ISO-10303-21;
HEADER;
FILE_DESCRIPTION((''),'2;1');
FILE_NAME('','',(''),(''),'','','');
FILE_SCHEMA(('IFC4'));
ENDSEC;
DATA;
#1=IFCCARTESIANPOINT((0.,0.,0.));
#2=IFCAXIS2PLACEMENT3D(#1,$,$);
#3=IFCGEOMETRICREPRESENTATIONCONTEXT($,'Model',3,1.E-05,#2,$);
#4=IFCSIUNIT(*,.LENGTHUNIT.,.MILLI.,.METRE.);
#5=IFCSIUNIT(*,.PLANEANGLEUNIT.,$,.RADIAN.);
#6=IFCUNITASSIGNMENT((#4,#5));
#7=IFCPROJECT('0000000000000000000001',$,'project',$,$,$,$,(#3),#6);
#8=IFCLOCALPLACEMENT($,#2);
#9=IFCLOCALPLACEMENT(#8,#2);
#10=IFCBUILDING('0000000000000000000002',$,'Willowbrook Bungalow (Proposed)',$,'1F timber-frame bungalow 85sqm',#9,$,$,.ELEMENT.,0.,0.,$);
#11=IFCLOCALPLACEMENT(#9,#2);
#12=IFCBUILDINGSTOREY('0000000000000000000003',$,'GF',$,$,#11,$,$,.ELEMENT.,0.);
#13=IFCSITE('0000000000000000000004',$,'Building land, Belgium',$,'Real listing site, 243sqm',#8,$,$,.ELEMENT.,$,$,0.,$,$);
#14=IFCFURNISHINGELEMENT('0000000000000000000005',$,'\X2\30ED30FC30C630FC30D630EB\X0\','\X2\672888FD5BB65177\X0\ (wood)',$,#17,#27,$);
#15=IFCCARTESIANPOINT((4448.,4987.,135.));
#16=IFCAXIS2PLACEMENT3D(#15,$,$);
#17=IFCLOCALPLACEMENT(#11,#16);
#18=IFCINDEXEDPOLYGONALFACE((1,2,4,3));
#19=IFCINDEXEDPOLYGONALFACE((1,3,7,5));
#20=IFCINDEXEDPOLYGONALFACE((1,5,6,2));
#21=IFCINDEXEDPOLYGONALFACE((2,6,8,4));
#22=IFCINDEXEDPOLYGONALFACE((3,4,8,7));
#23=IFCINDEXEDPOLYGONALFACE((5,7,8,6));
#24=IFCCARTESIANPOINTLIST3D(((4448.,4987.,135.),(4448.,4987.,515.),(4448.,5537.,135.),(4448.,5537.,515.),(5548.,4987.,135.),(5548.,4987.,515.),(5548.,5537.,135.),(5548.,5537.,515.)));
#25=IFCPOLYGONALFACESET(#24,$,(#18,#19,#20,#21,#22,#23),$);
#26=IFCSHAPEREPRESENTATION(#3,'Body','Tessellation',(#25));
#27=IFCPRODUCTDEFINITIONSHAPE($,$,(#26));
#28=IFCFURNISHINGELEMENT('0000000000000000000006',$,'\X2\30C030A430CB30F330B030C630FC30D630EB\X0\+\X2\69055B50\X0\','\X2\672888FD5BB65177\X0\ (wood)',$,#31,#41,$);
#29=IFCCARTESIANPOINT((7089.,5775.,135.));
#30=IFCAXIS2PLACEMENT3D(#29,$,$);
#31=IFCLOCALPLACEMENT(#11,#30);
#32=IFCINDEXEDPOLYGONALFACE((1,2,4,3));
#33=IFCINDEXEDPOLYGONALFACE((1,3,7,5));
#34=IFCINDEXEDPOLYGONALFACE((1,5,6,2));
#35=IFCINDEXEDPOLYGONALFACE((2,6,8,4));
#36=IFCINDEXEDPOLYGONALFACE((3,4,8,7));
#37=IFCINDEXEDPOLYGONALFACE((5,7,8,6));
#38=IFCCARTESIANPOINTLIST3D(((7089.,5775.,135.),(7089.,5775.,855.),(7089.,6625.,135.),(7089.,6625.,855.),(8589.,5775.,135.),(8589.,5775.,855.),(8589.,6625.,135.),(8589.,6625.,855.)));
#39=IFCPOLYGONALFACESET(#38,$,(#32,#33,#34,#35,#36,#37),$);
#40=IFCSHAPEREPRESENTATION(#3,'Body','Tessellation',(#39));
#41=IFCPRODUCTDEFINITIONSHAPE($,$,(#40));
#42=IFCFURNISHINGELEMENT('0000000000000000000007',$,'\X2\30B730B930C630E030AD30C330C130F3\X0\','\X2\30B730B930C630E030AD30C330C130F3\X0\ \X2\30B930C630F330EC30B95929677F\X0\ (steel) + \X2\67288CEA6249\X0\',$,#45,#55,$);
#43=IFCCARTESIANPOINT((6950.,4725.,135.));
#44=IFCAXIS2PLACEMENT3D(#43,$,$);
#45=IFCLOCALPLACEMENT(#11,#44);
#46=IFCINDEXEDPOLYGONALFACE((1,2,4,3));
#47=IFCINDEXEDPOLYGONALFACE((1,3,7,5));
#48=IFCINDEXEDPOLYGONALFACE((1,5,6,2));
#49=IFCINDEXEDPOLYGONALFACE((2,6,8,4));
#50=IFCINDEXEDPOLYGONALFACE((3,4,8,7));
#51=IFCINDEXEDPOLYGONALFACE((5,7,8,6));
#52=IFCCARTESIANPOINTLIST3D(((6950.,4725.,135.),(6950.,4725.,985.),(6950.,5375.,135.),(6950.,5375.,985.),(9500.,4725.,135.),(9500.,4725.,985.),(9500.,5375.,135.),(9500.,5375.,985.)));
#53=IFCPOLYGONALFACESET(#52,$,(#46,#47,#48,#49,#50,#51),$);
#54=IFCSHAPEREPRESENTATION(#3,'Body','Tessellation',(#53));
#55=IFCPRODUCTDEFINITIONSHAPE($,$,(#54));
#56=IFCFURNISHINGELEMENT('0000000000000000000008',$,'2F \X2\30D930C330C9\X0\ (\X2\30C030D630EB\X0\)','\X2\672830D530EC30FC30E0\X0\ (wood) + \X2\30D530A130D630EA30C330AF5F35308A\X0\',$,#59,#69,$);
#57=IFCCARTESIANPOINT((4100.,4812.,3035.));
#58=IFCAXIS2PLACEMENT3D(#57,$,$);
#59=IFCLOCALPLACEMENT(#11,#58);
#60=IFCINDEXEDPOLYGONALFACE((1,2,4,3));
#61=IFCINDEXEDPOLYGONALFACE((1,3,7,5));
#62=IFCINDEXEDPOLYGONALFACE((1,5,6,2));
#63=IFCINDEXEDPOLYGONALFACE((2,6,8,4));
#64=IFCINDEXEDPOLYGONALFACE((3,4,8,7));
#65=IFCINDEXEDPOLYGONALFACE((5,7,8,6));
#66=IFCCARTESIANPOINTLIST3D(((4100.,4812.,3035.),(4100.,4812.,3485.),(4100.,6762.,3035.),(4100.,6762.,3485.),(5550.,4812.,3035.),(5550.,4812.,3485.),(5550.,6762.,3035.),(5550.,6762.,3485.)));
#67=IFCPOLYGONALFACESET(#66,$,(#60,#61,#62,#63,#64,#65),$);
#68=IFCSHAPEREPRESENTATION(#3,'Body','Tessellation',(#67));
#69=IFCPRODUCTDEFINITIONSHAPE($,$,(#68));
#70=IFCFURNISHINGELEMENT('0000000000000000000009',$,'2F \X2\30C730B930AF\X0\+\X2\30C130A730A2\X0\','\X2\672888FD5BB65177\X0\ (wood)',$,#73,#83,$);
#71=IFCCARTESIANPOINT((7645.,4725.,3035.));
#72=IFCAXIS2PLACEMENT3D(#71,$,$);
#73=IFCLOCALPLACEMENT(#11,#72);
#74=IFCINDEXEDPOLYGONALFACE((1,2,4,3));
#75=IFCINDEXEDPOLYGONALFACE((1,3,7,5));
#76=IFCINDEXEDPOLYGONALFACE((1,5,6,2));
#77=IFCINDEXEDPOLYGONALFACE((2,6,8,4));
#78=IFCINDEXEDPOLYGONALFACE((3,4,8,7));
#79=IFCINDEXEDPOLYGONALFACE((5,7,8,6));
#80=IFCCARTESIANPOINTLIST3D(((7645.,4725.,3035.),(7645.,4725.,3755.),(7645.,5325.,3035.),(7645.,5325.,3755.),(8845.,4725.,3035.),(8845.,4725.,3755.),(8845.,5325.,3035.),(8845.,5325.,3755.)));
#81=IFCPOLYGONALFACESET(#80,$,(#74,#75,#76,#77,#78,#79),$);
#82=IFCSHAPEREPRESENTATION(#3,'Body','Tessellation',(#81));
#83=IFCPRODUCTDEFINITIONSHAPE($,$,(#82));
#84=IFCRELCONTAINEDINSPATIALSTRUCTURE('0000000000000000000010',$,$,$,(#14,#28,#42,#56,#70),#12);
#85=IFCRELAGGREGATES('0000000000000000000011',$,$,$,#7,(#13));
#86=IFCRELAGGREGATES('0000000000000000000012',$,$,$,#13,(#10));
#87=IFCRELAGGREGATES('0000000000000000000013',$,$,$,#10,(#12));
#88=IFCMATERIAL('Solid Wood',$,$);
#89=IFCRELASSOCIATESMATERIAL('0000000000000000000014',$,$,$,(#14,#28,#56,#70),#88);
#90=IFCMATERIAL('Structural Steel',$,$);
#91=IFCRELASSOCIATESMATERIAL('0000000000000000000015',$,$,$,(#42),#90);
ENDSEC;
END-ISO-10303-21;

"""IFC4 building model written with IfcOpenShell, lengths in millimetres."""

from ifc_helpers import new_model, si_unit, frame, frame_2d, origin, place, context, project, spatial, rectangle, extrude, material, element, save


model = new_model("IFC4")

# Units and contexts
model_context = context("Model", 3, precision=1e-05, world=origin())
ifc_project = project(units=[si_unit("LENGTHUNIT", "METRE", prefix="MILLI"), si_unit("PLANEANGLEUNIT", "RADIAN")], contexts=[model_context])

# Site, building, storey
site_placement = place(None, origin())
site = spatial("IfcSite", under=ifc_project, at=site_placement, Name="Building land, Belgium", ObjectType="Real listing site, 243sqm", CompositionType="ELEMENT", RefElevation=0.0)
building_placement = place(site_placement, origin())
building = spatial("IfcBuilding", under=site, at=building_placement, Name="Willowbrook Bungalow (Proposed)", ObjectType="1F timber-frame bungalow 85sqm", CompositionType="ELEMENT", ElevationOfRefHeight=0.0, ElevationOfTerrain=0.0)
storey_placement = place(building_placement, origin())
storey = spatial("IfcBuildingStorey", under=building, at=storey_placement, Name="GF", CompositionType="ELEMENT", Elevation=0.0)

# Shared definitions
ifc_material_1 = material(Name="Solid Wood")

# Shared definitions
ifc_material_2 = material(Name="Structural Steel")

# Furnishing elements
furnishing_1_placement = place(storey_placement, frame((4448.0, 4987.0, 135.0)))
element("IfcFurnishingElement", 1, at=furnishing_1_placement, inside=storey, material=ifc_material_1, Name="ローテーブル", Description="木製家具 (wood)", context=model_context, shape_type="SweptSolid", body=[
    extrude(rectangle(XDim=1100.0, YDim=550.0, at=frame_2d((550.0, 275.0))), frame((4448.0, 4987.0, 135.0)), (0.0, 0.0, 1.0), 380.0),
])
furnishing_2_placement = place(storey_placement, frame((7089.0, 5775.0, 135.0)))
element("IfcFurnishingElement", 2, at=furnishing_2_placement, inside=storey, material=ifc_material_1, Name="ダイニングテーブル+椅子", Description="木製家具 (wood)", context=model_context, shape_type="SweptSolid", body=[
    extrude(rectangle(XDim=1500.0, YDim=850.0, at=frame_2d((750.0, 425.0))), frame((7089.0, 5775.0, 135.0)), (0.0, 0.0, 1.0), 720.0),
])
furnishing_3_placement = place(storey_placement, frame((6950.0, 4725.0, 135.0)))
element("IfcFurnishingElement", 3, at=furnishing_3_placement, inside=storey, material=ifc_material_2, Name="システムキッチン", Description="システムキッチン ステンレス天板 (steel) + 木質扉", context=model_context, shape_type="SweptSolid", body=[
    extrude(rectangle(XDim=2550.0, YDim=650.0, at=frame_2d((1275.0, 325.0))), frame((6950.0, 4725.0, 135.0)), (0.0, 0.0, 1.0), 850.0),
])
furnishing_4_placement = place(storey_placement, frame((4100.0, 4812.0, 3035.0)))
element("IfcFurnishingElement", 4, at=furnishing_4_placement, inside=storey, material=ifc_material_1, Name="2F ベッド (ダブル)", Description="木フレーム (wood) + ファブリック張り", context=model_context, shape_type="SweptSolid", body=[
    extrude(rectangle(XDim=1450.0, YDim=1950.0, at=frame_2d((725.0, 975.0))), frame((4100.0, 4812.0, 3035.0)), (0.0, 0.0, 1.0), 450.0),
])
furnishing_5_placement = place(storey_placement, frame((7645.0, 4725.0, 3035.0)))
element("IfcFurnishingElement", 5, at=furnishing_5_placement, inside=storey, material=ifc_material_1, Name="2F デスク+チェア", Description="木製家具 (wood)", context=model_context, shape_type="SweptSolid", body=[
    extrude(rectangle(XDim=1200.0, YDim=600.0, at=frame_2d((600.0, 300.0))), frame((7645.0, 4725.0, 3035.0)), (0.0, 0.0, 1.0), 720.0),
])

save(model, "model.ifc")
